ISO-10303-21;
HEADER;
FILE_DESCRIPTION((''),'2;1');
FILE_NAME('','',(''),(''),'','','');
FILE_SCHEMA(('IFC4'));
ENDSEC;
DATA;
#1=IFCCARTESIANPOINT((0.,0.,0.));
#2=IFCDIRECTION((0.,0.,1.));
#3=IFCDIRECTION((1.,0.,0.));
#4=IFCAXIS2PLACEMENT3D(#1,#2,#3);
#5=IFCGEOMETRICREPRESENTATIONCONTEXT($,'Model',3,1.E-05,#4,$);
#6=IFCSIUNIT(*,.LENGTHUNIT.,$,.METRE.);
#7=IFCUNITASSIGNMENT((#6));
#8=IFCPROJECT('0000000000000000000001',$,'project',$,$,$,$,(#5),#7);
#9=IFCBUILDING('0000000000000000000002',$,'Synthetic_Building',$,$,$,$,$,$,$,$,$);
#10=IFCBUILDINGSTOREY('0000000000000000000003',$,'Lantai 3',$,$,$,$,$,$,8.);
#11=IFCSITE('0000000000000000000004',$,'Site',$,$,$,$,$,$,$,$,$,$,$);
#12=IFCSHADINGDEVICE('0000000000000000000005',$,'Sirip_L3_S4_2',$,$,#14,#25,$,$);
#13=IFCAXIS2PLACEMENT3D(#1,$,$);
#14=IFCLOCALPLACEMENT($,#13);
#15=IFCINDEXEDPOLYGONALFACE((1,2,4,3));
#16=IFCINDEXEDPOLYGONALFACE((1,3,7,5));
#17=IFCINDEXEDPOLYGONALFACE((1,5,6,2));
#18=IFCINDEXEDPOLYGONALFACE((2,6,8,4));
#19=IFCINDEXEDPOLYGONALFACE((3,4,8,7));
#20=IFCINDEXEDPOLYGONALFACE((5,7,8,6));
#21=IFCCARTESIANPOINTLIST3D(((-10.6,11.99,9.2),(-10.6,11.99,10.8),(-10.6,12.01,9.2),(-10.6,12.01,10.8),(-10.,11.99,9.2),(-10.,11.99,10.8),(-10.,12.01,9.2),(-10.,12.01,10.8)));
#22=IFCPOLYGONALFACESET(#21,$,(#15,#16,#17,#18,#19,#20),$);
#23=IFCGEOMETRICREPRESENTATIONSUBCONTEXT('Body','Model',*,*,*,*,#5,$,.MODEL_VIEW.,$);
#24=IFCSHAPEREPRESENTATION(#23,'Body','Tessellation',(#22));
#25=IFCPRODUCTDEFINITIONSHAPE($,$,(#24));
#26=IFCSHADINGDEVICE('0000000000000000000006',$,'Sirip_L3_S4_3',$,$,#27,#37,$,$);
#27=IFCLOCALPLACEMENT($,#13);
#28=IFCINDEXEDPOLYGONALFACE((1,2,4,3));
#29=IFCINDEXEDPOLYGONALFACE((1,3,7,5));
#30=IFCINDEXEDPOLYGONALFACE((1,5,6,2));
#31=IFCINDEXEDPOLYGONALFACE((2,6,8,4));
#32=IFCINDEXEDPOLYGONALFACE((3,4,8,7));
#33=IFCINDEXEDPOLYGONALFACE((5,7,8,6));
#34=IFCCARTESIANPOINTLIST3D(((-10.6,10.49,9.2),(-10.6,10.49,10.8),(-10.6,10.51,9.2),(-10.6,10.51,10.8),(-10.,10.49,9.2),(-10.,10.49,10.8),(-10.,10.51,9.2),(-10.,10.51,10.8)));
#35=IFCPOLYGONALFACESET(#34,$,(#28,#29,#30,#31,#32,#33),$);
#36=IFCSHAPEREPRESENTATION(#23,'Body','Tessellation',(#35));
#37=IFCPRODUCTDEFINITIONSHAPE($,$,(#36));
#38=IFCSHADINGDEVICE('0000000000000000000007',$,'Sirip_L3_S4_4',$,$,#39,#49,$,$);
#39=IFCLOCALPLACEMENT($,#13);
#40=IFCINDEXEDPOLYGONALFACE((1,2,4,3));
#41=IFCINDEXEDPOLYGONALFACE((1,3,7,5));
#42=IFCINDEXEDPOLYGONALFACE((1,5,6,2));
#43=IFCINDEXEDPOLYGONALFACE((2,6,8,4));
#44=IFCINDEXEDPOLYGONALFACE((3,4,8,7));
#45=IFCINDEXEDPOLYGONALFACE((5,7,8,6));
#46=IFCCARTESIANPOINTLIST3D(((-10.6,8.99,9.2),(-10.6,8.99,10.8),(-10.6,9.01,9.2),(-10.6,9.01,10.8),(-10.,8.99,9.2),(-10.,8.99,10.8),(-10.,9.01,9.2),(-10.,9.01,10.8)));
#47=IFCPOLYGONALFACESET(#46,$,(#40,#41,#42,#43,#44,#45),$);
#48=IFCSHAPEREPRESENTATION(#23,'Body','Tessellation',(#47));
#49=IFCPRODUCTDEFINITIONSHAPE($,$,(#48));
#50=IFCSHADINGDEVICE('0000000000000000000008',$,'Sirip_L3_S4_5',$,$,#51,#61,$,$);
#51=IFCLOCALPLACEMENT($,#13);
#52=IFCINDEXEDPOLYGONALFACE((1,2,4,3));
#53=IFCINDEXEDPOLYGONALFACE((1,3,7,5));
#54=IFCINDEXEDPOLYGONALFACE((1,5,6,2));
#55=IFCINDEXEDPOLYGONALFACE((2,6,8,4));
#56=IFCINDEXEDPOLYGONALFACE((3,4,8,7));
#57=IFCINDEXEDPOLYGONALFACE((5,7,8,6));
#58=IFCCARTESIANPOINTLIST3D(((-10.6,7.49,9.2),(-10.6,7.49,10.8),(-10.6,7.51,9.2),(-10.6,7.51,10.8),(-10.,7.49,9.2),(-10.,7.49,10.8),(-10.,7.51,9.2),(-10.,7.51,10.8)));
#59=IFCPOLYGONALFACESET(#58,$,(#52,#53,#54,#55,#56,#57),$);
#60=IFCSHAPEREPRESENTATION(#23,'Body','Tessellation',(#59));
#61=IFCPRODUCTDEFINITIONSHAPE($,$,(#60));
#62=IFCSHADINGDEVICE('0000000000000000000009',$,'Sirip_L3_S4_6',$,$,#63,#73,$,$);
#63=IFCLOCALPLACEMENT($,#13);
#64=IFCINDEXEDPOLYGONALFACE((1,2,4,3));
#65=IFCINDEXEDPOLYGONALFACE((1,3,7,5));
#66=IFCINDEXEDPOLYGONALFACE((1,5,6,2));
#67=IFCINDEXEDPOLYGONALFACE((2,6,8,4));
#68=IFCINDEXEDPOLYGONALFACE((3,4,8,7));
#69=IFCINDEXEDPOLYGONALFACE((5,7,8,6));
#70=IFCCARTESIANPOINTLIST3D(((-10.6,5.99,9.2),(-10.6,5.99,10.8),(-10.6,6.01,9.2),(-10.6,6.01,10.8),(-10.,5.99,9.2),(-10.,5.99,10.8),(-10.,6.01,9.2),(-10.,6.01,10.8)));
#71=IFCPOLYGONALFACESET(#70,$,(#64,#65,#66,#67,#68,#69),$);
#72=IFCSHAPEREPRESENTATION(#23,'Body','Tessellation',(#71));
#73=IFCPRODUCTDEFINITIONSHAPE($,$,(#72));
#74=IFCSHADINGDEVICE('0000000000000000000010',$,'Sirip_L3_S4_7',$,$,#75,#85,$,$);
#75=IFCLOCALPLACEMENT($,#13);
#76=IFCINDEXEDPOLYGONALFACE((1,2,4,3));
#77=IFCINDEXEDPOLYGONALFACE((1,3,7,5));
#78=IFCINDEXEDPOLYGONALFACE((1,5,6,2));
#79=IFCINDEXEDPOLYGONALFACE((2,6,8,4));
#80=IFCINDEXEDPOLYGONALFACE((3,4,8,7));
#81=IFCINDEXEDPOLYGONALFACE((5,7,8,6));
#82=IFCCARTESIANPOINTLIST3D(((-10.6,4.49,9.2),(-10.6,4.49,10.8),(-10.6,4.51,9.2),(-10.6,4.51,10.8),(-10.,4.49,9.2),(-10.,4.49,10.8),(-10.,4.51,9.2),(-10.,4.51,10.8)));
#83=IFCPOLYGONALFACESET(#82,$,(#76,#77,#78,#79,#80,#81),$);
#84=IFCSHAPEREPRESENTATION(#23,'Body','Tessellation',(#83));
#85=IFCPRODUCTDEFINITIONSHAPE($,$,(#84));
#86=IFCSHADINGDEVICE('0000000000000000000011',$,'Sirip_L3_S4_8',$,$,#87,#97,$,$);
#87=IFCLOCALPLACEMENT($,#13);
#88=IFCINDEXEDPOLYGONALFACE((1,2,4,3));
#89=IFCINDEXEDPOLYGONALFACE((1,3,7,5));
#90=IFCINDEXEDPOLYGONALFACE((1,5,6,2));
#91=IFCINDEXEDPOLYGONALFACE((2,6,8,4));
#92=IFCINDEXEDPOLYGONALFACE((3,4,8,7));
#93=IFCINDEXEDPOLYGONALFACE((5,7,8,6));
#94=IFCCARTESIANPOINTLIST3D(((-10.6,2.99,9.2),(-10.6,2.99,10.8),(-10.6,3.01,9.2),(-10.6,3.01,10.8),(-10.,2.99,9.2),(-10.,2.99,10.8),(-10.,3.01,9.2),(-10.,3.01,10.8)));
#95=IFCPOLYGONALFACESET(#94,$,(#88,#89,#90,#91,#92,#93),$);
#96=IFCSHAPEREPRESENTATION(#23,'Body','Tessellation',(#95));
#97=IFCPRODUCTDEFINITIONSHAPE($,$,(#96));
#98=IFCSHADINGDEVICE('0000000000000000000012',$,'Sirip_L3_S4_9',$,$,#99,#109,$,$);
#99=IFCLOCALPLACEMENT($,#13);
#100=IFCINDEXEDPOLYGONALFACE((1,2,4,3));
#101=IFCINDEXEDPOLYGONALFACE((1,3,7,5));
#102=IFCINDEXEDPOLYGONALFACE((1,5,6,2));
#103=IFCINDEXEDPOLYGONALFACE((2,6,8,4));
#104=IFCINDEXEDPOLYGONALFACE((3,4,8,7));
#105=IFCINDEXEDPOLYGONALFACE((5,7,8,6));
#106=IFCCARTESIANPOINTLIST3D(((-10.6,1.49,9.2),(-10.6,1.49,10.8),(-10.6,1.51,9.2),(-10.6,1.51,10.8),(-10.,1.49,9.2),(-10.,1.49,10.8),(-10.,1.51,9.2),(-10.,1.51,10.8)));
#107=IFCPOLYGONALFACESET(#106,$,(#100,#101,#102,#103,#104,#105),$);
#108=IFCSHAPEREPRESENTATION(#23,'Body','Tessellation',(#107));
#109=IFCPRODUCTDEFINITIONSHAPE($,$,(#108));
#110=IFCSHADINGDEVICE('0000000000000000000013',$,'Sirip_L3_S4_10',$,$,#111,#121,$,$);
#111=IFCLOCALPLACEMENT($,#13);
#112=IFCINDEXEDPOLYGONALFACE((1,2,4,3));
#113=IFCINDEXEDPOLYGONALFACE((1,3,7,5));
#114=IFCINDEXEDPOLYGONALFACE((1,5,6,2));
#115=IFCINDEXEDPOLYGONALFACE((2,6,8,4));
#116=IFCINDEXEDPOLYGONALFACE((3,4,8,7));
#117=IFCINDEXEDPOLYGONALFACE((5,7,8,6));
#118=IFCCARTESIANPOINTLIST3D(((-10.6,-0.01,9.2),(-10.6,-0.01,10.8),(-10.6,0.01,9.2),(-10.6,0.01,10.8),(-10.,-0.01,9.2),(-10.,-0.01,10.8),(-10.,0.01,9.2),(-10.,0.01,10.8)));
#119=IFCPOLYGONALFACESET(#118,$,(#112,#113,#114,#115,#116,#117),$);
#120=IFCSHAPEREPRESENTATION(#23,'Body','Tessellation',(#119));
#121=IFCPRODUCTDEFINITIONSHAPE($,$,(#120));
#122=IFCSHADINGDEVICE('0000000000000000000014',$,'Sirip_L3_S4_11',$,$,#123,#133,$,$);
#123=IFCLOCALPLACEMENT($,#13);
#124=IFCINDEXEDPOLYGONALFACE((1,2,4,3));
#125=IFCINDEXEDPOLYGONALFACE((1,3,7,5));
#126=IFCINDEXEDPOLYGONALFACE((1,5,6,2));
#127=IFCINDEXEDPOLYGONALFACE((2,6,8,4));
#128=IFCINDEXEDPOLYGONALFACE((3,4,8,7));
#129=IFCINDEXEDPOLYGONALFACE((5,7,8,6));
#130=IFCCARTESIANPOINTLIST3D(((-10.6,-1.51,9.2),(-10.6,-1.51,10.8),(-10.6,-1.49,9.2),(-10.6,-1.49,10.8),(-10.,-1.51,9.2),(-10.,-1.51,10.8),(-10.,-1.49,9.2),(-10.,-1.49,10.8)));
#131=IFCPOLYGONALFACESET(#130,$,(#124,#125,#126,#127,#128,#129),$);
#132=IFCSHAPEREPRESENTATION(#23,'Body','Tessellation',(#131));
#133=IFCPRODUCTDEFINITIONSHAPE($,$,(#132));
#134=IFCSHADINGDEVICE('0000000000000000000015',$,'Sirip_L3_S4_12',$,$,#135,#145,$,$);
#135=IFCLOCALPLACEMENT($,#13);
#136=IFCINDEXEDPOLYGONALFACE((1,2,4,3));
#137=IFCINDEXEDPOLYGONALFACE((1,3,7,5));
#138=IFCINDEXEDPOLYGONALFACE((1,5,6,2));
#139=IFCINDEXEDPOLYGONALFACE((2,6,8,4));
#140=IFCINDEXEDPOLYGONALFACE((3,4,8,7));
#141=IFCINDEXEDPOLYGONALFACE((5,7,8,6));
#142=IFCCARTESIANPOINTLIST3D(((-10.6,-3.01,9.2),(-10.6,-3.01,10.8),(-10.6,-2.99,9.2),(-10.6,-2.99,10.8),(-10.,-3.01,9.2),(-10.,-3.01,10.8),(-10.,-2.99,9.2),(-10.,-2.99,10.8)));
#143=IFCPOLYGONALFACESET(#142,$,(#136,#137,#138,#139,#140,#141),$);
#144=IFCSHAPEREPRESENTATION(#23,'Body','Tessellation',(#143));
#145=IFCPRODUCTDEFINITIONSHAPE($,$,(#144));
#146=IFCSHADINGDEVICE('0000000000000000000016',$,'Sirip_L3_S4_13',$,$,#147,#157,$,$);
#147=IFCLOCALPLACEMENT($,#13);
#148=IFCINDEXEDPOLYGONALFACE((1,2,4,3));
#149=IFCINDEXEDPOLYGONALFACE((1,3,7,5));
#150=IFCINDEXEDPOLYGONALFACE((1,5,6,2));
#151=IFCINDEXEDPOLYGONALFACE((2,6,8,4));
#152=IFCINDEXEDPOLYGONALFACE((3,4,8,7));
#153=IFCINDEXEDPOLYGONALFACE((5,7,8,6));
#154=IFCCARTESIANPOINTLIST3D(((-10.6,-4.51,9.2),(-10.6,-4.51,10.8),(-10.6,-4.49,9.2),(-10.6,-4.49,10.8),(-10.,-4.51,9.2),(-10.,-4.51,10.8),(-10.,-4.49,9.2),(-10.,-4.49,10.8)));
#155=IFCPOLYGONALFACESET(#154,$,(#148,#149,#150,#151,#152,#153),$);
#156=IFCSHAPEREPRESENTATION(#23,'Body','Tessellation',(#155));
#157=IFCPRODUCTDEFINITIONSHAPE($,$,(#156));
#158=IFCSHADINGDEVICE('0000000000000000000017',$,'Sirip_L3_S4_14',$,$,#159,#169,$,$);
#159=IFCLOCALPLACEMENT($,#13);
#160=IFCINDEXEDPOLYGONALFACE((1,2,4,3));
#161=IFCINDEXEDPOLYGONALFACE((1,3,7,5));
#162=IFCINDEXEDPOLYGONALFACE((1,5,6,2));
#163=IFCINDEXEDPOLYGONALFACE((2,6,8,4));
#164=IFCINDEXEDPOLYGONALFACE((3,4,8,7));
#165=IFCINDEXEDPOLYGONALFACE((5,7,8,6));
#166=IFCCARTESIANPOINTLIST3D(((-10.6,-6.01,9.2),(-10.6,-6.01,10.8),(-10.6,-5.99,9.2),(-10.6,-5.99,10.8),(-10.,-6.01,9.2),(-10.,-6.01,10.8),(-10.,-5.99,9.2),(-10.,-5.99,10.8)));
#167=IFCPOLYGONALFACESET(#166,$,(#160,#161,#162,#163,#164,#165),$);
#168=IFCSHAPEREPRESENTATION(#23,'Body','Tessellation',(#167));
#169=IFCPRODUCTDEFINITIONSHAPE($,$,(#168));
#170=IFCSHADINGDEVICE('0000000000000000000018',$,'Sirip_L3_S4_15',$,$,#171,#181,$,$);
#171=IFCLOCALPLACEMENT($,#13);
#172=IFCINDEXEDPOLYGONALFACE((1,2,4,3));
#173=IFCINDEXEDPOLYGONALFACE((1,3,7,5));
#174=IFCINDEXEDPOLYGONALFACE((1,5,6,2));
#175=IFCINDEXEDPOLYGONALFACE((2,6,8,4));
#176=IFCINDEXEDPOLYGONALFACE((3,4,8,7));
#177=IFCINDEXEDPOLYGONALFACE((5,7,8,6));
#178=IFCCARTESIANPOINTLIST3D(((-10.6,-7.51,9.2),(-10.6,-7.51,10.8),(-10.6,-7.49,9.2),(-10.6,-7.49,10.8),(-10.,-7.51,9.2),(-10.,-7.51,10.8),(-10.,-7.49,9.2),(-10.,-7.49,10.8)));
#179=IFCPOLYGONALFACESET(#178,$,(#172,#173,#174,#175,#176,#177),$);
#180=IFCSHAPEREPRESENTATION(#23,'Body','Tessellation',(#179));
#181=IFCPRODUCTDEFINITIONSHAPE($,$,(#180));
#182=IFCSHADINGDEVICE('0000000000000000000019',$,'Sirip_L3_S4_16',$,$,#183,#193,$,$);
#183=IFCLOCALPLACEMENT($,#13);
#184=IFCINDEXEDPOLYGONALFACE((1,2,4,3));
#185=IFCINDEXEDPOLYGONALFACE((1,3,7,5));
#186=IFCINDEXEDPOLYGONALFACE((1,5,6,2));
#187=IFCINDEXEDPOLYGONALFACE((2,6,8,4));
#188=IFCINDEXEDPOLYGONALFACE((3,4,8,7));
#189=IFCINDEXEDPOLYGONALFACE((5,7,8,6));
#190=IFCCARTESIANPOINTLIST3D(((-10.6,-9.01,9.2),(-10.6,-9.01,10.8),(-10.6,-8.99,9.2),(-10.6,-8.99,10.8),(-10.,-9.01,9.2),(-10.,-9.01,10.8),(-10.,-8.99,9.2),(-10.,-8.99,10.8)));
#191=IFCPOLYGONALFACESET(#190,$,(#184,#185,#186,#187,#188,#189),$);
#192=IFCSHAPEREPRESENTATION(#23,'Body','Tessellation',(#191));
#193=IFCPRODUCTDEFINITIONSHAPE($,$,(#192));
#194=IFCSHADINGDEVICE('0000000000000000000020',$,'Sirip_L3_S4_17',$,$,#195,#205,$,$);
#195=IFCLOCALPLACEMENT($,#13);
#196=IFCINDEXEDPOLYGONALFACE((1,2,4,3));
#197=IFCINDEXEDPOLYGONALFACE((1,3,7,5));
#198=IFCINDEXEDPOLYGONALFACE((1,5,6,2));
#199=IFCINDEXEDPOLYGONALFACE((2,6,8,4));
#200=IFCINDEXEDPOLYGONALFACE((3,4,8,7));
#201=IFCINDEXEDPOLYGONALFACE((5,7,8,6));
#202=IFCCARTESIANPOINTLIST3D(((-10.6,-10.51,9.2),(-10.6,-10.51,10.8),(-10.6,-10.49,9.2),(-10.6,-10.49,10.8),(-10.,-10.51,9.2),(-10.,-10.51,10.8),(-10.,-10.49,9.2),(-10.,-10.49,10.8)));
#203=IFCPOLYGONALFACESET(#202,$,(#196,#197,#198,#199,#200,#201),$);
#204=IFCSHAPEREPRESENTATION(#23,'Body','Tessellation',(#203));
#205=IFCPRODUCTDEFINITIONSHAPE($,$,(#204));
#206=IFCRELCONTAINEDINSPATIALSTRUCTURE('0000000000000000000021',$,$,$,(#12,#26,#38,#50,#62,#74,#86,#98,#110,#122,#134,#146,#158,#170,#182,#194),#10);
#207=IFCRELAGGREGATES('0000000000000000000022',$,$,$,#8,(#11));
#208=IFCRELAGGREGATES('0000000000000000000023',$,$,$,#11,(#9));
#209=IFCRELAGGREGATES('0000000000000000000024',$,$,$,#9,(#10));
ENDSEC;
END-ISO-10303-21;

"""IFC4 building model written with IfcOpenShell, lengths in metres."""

from ifc_helpers import new_model, si_unit, frame, origin_with_axes, place, context, subcontext, project, spatial, polyline, outline, extrude, element, save


model = new_model("IFC4")

# Units and contexts
model_context = context("Model", 3, precision=1e-05, world=origin_with_axes())
body_context = subcontext(model_context, "Body", "Model", "MODEL_VIEW")
ifc_project = project(units=[si_unit("LENGTHUNIT", "METRE")], contexts=[model_context])

# Site, building, storey
site = spatial("IfcSite", under=ifc_project, Name="Site")
building = spatial("IfcBuilding", under=site, Name="Synthetic_Building")
storey = spatial("IfcBuildingStorey", under=building, Name="Lantai 3", Elevation=8.0)

# Shading devices
shading_device_1_placement = place(None, origin_with_axes())
element("IfcShadingDevice", 1, at=shading_device_1_placement, inside=storey, Name="Sirip_L3_S4_2", context=body_context, shape_type="SweptSolid", body=[
    extrude(outline(polyline([(-10.0, 12.01), (-10.0, 11.99), (-10.6, 11.99), (-10.6, 12.01), (-10.0, 12.01)])), frame((0.0, 0.0, 9.2), z_axis=(0.0, 0.0, 1.0), x_axis=(1.0, 0.0, 0.0)), (0.0, 0.0, 1.0), 1.6),
])
shading_device_2_placement = place(None, origin_with_axes())
element("IfcShadingDevice", 2, at=shading_device_2_placement, inside=storey, Name="Sirip_L3_S4_3", context=body_context, shape_type="SweptSolid", body=[
    extrude(outline(polyline([(-10.0, 10.51), (-10.0, 10.49), (-10.6, 10.49), (-10.6, 10.51), (-10.0, 10.51)])), frame((0.0, 0.0, 9.2), z_axis=(0.0, 0.0, 1.0), x_axis=(1.0, 0.0, 0.0)), (0.0, 0.0, 1.0), 1.6),
])
shading_device_3_placement = place(None, origin_with_axes())
element("IfcShadingDevice", 3, at=shading_device_3_placement, inside=storey, Name="Sirip_L3_S4_4", context=body_context, shape_type="SweptSolid", body=[
    extrude(outline(polyline([(-10.0, 9.01), (-10.0, 8.99), (-10.6, 8.99), (-10.6, 9.01), (-10.0, 9.01)])), frame((0.0, 0.0, 9.2), z_axis=(0.0, 0.0, 1.0), x_axis=(1.0, 0.0, 0.0)), (0.0, 0.0, 1.0), 1.6),
])
shading_device_4_placement = place(None, origin_with_axes())
element("IfcShadingDevice", 4, at=shading_device_4_placement, inside=storey, Name="Sirip_L3_S4_5", context=body_context, shape_type="SweptSolid", body=[
    extrude(outline(polyline([(-10.0, 7.51), (-10.0, 7.49), (-10.6, 7.49), (-10.6, 7.51), (-10.0, 7.51)])), frame((0.0, 0.0, 9.2), z_axis=(0.0, 0.0, 1.0), x_axis=(1.0, 0.0, 0.0)), (0.0, 0.0, 1.0), 1.6),
])
shading_device_5_placement = place(None, origin_with_axes())
element("IfcShadingDevice", 5, at=shading_device_5_placement, inside=storey, Name="Sirip_L3_S4_6", context=body_context, shape_type="SweptSolid", body=[
    extrude(outline(polyline([(-10.0, 6.01), (-10.0, 5.99), (-10.6, 5.99), (-10.6, 6.01), (-10.0, 6.01)])), frame((0.0, 0.0, 9.2), z_axis=(0.0, 0.0, 1.0), x_axis=(1.0, 0.0, 0.0)), (0.0, 0.0, 1.0), 1.6),
])
shading_device_6_placement = place(None, origin_with_axes())
element("IfcShadingDevice", 6, at=shading_device_6_placement, inside=storey, Name="Sirip_L3_S4_7", context=body_context, shape_type="SweptSolid", body=[
    extrude(outline(polyline([(-10.0, 4.51), (-10.0, 4.49), (-10.6, 4.49), (-10.6, 4.51), (-10.0, 4.51)])), frame((0.0, 0.0, 9.2), z_axis=(0.0, 0.0, 1.0), x_axis=(1.0, 0.0, 0.0)), (0.0, 0.0, 1.0), 1.6),
])
shading_device_7_placement = place(None, origin_with_axes())
element("IfcShadingDevice", 7, at=shading_device_7_placement, inside=storey, Name="Sirip_L3_S4_8", context=body_context, shape_type="SweptSolid", body=[
    extrude(outline(polyline([(-10.0, 3.01), (-10.0, 2.99), (-10.6, 2.99), (-10.6, 3.01), (-10.0, 3.01)])), frame((0.0, 0.0, 9.2), z_axis=(0.0, 0.0, 1.0), x_axis=(1.0, 0.0, 0.0)), (0.0, 0.0, 1.0), 1.6),
])
shading_device_8_placement = place(None, origin_with_axes())
element("IfcShadingDevice", 8, at=shading_device_8_placement, inside=storey, Name="Sirip_L3_S4_9", context=body_context, shape_type="SweptSolid", body=[
    extrude(outline(polyline([(-10.0, 1.51), (-10.0, 1.49), (-10.6, 1.49), (-10.6, 1.51), (-10.0, 1.51)])), frame((0.0, 0.0, 9.2), z_axis=(0.0, 0.0, 1.0), x_axis=(1.0, 0.0, 0.0)), (0.0, 0.0, 1.0), 1.6),
])
shading_device_9_placement = place(None, origin_with_axes())
element("IfcShadingDevice", 9, at=shading_device_9_placement, inside=storey, Name="Sirip_L3_S4_10", context=body_context, shape_type="SweptSolid", body=[
    extrude(outline(polyline([(-10.0, 0.01), (-10.0, -0.01), (-10.6, -0.01), (-10.6, 0.01), (-10.0, 0.01)])), frame((0.0, 0.0, 9.2), z_axis=(0.0, 0.0, 1.0), x_axis=(1.0, 0.0, 0.0)), (0.0, 0.0, 1.0), 1.6),
])
shading_device_10_placement = place(None, origin_with_axes())
element("IfcShadingDevice", 10, at=shading_device_10_placement, inside=storey, Name="Sirip_L3_S4_11", context=body_context, shape_type="SweptSolid", body=[
    extrude(outline(polyline([(-10.0, -1.49), (-10.0, -1.51), (-10.6, -1.51), (-10.6, -1.49), (-10.0, -1.49)])), frame((0.0, 0.0, 9.2), z_axis=(0.0, 0.0, 1.0), x_axis=(1.0, 0.0, 0.0)), (0.0, 0.0, 1.0), 1.6),
])
shading_device_11_placement = place(None, origin_with_axes())
element("IfcShadingDevice", 11, at=shading_device_11_placement, inside=storey, Name="Sirip_L3_S4_12", context=body_context, shape_type="SweptSolid", body=[
    extrude(outline(polyline([(-10.0, -2.99), (-10.0, -3.01), (-10.6, -3.01), (-10.6, -2.99), (-10.0, -2.99)])), frame((0.0, 0.0, 9.2), z_axis=(0.0, 0.0, 1.0), x_axis=(1.0, 0.0, 0.0)), (0.0, 0.0, 1.0), 1.6),
])
shading_device_12_placement = place(None, origin_with_axes())
element("IfcShadingDevice", 12, at=shading_device_12_placement, inside=storey, Name="Sirip_L3_S4_13", context=body_context, shape_type="SweptSolid", body=[
    extrude(outline(polyline([(-10.0, -4.49), (-10.0, -4.51), (-10.6, -4.51), (-10.6, -4.49), (-10.0, -4.49)])), frame((0.0, 0.0, 9.2), z_axis=(0.0, 0.0, 1.0), x_axis=(1.0, 0.0, 0.0)), (0.0, 0.0, 1.0), 1.6),
])
shading_device_13_placement = place(None, origin_with_axes())
element("IfcShadingDevice", 13, at=shading_device_13_placement, inside=storey, Name="Sirip_L3_S4_14", context=body_context, shape_type="SweptSolid", body=[
    extrude(outline(polyline([(-10.0, -5.99), (-10.0, -6.01), (-10.6, -6.01), (-10.6, -5.99), (-10.0, -5.99)])), frame((0.0, 0.0, 9.2), z_axis=(0.0, 0.0, 1.0), x_axis=(1.0, 0.0, 0.0)), (0.0, 0.0, 1.0), 1.6),
])
shading_device_14_placement = place(None, origin_with_axes())
element("IfcShadingDevice", 14, at=shading_device_14_placement, inside=storey, Name="Sirip_L3_S4_15", context=body_context, shape_type="SweptSolid", body=[
    extrude(outline(polyline([(-10.0, -7.49), (-10.0, -7.51), (-10.6, -7.51), (-10.6, -7.49), (-10.0, -7.49)])), frame((0.0, 0.0, 9.2), z_axis=(0.0, 0.0, 1.0), x_axis=(1.0, 0.0, 0.0)), (0.0, 0.0, 1.0), 1.6),
])
shading_device_15_placement = place(None, origin_with_axes())
element("IfcShadingDevice", 15, at=shading_device_15_placement, inside=storey, Name="Sirip_L3_S4_16", context=body_context, shape_type="SweptSolid", body=[
    extrude(outline(polyline([(-10.0, -8.99), (-10.0, -9.01), (-10.6, -9.01), (-10.6, -8.99), (-10.0, -8.99)])), frame((0.0, 0.0, 9.2), z_axis=(0.0, 0.0, 1.0), x_axis=(1.0, 0.0, 0.0)), (0.0, 0.0, 1.0), 1.6),
])
shading_device_16_placement = place(None, origin_with_axes())
element("IfcShadingDevice", 16, at=shading_device_16_placement, inside=storey, Name="Sirip_L3_S4_17", context=body_context, shape_type="SweptSolid", body=[
    extrude(outline(polyline([(-10.0, -10.49), (-10.0, -10.51), (-10.6, -10.51), (-10.6, -10.49), (-10.0, -10.49)])), frame((0.0, 0.0, 9.2), z_axis=(0.0, 0.0, 1.0), x_axis=(1.0, 0.0, 0.0)), (0.0, 0.0, 1.0), 1.6),
])

save(model, "model.ifc")
